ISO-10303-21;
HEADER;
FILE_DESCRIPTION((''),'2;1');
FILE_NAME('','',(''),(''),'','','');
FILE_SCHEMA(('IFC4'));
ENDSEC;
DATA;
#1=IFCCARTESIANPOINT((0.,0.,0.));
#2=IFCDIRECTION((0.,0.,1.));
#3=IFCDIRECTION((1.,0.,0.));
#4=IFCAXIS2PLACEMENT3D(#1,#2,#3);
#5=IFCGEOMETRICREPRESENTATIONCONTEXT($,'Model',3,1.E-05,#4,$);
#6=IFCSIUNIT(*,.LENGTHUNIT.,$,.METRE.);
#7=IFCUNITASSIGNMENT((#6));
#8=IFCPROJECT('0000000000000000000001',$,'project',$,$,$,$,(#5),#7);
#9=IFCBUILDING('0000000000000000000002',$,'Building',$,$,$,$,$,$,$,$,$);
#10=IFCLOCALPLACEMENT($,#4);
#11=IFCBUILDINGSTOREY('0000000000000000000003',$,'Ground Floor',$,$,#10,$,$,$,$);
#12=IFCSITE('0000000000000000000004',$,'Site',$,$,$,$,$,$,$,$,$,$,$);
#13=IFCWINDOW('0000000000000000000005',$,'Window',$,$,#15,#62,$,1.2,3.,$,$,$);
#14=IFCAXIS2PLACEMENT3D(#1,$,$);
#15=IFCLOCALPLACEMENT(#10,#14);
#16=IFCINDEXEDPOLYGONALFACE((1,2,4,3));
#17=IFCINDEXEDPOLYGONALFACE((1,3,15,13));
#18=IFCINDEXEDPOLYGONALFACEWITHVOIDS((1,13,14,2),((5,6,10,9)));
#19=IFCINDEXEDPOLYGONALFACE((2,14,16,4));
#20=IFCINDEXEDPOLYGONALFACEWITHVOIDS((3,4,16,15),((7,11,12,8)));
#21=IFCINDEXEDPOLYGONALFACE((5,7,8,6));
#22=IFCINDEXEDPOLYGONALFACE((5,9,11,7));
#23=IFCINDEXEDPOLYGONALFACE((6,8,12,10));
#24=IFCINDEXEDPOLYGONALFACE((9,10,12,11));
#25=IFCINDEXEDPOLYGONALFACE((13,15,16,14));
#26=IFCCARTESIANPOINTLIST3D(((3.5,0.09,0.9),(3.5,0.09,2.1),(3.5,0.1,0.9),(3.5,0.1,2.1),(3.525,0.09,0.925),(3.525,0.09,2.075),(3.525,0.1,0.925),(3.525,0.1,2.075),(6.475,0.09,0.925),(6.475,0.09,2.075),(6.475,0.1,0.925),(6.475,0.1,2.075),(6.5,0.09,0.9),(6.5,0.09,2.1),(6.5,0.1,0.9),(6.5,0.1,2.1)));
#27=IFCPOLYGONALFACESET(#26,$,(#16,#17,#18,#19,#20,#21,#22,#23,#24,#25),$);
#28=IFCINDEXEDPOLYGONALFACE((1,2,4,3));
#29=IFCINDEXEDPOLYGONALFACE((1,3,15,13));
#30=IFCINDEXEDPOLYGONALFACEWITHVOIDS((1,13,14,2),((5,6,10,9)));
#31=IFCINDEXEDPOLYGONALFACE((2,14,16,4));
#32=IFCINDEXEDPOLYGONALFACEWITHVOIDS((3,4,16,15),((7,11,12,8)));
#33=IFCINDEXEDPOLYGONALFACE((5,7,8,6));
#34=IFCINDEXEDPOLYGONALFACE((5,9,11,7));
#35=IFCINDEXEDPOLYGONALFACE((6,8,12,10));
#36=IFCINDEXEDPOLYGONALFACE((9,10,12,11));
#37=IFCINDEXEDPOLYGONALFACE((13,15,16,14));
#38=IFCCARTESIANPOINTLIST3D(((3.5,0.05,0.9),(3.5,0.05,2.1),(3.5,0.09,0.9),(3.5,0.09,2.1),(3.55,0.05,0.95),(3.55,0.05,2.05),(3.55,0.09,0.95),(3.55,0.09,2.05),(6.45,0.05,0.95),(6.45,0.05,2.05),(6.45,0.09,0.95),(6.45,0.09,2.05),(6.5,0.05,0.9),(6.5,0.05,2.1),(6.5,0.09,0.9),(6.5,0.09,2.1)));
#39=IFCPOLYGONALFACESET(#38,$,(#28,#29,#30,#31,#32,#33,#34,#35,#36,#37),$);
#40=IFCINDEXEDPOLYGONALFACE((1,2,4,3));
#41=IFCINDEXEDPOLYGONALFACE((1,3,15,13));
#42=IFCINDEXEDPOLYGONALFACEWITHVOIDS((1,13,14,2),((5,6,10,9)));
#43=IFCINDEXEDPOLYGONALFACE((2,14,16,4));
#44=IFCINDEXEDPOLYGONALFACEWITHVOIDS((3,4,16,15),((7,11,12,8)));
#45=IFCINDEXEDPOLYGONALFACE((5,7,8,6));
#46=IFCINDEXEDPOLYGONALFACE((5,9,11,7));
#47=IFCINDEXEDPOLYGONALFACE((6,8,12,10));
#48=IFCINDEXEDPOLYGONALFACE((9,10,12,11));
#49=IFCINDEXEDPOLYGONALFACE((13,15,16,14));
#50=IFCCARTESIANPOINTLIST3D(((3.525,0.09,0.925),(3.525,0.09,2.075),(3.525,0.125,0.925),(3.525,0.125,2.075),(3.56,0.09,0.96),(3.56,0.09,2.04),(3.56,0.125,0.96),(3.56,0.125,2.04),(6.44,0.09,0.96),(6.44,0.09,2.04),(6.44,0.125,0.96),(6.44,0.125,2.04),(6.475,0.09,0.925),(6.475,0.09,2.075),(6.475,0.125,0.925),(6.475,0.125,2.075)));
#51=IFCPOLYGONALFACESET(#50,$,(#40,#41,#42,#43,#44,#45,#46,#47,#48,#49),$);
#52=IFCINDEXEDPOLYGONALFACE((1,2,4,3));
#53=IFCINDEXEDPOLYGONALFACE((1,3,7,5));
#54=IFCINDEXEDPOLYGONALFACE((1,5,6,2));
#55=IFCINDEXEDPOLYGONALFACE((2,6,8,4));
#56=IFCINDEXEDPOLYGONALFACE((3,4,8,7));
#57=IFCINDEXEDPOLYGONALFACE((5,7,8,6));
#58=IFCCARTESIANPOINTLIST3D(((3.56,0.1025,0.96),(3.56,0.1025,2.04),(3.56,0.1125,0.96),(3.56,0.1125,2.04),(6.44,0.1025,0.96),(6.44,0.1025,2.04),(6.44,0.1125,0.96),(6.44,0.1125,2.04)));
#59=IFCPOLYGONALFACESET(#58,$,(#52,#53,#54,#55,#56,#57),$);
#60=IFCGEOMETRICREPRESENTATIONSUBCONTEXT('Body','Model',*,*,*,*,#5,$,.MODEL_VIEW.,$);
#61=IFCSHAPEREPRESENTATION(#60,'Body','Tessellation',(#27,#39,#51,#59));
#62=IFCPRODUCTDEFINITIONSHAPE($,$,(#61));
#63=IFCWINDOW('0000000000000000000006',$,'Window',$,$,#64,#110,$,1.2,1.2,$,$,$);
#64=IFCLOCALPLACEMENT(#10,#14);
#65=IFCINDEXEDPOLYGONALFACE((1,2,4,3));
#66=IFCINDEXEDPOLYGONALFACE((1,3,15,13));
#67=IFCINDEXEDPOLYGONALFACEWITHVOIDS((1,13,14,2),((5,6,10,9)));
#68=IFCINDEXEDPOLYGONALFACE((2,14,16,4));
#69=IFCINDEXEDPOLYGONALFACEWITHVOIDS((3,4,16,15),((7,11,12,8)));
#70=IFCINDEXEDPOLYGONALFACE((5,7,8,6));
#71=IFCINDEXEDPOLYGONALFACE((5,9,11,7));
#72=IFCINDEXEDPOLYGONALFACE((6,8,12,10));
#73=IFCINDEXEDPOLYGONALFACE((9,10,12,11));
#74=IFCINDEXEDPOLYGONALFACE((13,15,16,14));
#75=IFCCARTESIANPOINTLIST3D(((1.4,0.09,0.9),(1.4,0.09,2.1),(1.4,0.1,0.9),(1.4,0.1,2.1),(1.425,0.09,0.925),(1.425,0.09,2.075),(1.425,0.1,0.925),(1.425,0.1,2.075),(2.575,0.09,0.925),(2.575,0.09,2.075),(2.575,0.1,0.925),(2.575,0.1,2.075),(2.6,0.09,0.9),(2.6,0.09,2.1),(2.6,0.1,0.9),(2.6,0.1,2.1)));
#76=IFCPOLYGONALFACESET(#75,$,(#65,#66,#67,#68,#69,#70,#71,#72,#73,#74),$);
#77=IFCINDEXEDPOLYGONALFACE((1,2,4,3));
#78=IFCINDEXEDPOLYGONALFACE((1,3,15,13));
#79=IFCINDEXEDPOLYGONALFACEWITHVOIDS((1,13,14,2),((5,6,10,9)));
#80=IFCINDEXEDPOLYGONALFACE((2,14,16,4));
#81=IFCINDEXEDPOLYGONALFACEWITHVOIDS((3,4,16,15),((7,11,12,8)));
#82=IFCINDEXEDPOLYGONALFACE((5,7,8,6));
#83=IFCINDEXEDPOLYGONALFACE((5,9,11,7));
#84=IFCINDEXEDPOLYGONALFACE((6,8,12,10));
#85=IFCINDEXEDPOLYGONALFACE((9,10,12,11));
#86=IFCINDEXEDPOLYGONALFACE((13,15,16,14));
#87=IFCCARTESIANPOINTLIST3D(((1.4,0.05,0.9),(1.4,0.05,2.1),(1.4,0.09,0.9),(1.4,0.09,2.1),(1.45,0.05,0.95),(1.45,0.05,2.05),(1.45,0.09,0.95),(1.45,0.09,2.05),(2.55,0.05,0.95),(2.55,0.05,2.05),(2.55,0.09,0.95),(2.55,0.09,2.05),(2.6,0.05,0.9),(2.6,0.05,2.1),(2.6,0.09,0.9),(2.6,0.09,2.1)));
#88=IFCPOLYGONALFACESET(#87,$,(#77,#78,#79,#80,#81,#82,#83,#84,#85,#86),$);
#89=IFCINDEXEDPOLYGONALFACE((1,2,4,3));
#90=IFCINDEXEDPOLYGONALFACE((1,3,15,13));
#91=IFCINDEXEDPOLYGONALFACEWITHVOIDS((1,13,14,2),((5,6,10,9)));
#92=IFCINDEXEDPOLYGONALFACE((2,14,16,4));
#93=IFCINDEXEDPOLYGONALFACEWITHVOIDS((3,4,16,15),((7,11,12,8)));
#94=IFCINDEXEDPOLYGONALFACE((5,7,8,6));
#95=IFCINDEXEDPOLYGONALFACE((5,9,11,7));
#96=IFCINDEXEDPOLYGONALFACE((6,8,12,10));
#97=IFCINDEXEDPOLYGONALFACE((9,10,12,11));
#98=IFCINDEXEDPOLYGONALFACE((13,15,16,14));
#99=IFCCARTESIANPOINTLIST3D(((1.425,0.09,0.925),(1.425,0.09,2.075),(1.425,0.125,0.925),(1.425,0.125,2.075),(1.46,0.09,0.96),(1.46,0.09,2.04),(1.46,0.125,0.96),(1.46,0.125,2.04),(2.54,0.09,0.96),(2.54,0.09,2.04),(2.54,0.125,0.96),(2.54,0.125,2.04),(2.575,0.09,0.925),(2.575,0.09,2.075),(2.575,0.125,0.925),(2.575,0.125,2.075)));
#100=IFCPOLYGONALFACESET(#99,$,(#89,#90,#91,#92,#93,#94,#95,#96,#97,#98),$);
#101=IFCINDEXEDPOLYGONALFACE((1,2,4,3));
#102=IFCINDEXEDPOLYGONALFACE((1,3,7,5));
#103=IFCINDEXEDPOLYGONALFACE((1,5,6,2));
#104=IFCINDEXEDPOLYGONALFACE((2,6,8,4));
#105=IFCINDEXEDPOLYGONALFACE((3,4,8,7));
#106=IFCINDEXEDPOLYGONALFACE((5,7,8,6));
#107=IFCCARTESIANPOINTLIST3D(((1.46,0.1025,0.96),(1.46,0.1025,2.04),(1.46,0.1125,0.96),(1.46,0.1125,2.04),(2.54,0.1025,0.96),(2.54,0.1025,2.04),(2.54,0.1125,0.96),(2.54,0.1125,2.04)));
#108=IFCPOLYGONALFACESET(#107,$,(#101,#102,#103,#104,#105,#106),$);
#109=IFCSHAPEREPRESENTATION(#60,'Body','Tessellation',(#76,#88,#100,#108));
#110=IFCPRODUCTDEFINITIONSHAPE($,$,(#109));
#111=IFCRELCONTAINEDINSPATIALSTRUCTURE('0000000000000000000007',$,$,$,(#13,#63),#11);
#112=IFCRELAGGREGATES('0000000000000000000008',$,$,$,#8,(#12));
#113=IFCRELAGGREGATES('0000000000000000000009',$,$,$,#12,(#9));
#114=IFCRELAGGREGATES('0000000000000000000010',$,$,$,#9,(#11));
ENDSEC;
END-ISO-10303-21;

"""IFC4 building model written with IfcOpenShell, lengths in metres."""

from ifc_helpers import new_model, si_unit, frame, origin_with_axes, place, context, subcontext, project, spatial, line, indexed_curve, outline, extrude, element, save


model = new_model("IFC4")

# Units and contexts
model_context = context("Model", 3, precision=1e-05, world=origin_with_axes())
body_context = subcontext(model_context, "Body", "Model", "MODEL_VIEW")
ifc_project = project(units=[si_unit("LENGTHUNIT", "METRE")], contexts=[model_context])

# Site, building, storey
site = spatial("IfcSite", under=ifc_project, Name="Site")
building = spatial("IfcBuilding", under=site, Name="Building")
storey_placement = place(None, origin_with_axes())
storey = spatial("IfcBuildingStorey", under=building, at=storey_placement, Name="Ground Floor")

# Windows
window_1_placement = place(storey_placement, frame((3.5, 0.0, 0.9), z_axis=(0.0, 0.0, 1.0), x_axis=(1.0, 0.0, 0.0)))
element("IfcWindow", 1, at=window_1_placement, inside=storey, Name="Window", OverallHeight=1.2, OverallWidth=3.0, context=body_context, shape_type="SweptSolid", body=[
    extrude(outline(indexed_curve([(0.0, 0.0), (3.0, 0.0), (3.0, 1.2), (0.0, 1.2)], segments=[line(1, 2, 3, 4, 1)]), holes=[indexed_curve([(0.025, 0.025), (2.975, 0.025), (2.975, 1.175), (0.025, 1.175)], segments=[line(1, 2, 3, 4, 1)])]), frame((0.0, 0.09, 0.0), z_axis=(0.0, -1.0, 0.0), x_axis=(1.0, 0.0, 0.0)), (0.0, 0.0, -1.0), 0.01),
    extrude(outline(indexed_curve([(0.0, 0.0), (3.0, 0.0), (3.0, 1.2), (0.0, 1.2)], segments=[line(1, 2, 3, 4, 1)]), holes=[indexed_curve([(0.05, 0.05), (2.95, 0.05), (2.95, 1.15), (0.05, 1.15)], segments=[line(1, 2, 3, 4, 1)])]), frame((0.0, 0.05, 0.0), z_axis=(0.0, -1.0, 0.0), x_axis=(1.0, 0.0, 0.0)), (0.0, 0.0, -1.0), 0.04),
    extrude(outline(indexed_curve([(0.0, 0.0), (2.95, 0.0), (2.95, 1.15), (0.0, 1.15)], segments=[line(1, 2, 3, 4, 1)]), holes=[indexed_curve([(0.035, 0.035), (2.915, 0.035), (2.915, 1.115), (0.035, 1.115)], segments=[line(1, 2, 3, 4, 1)])]), frame((0.025, 0.09, 0.025), z_axis=(0.0, -1.0, 0.0), x_axis=(1.0, 0.0, 0.0)), (0.0, 0.0, -1.0), 0.035),
    extrude(outline(indexed_curve([(0.035, 0.035), (2.915, 0.035), (2.915, 1.115), (0.035, 1.115)], segments=[line(1, 2, 3, 4, 1)])), frame((0.025, 0.1025, 0.025), z_axis=(0.0, -1.0, 0.0), x_axis=(1.0, 0.0, 0.0)), (0.0, 0.0, -1.0), 0.01),
])
window_2_placement = place(storey_placement, frame((1.4, 0.0, 0.9), z_axis=(0.0, 0.0, 1.0), x_axis=(1.0, 0.0, 0.0)))
element("IfcWindow", 2, at=window_2_placement, inside=storey, Name="Window", OverallHeight=1.2, OverallWidth=1.2, context=body_context, shape_type="SweptSolid", body=[
    extrude(outline(indexed_curve([(0.0, 0.0), (1.2, 0.0), (1.2, 1.2), (0.0, 1.2)], segments=[line(1, 2, 3, 4, 1)]), holes=[indexed_curve([(0.025, 0.025), (1.175, 0.025), (1.175, 1.175), (0.025, 1.175)], segments=[line(1, 2, 3, 4, 1)])]), frame((0.0, 0.09, 0.0), z_axis=(0.0, -1.0, 0.0), x_axis=(1.0, 0.0, 0.0)), (0.0, 0.0, -1.0), 0.01),
    extrude(outline(indexed_curve([(0.0, 0.0), (1.2, 0.0), (1.2, 1.2), (0.0, 1.2)], segments=[line(1, 2, 3, 4, 1)]), holes=[indexed_curve([(0.05, 0.05), (1.15, 0.05), (1.15, 1.15), (0.05, 1.15)], segments=[line(1, 2, 3, 4, 1)])]), frame((0.0, 0.05, 0.0), z_axis=(0.0, -1.0, 0.0), x_axis=(1.0, 0.0, 0.0)), (0.0, 0.0, -1.0), 0.04),
    extrude(outline(indexed_curve([(0.0, 0.0), (1.15, 0.0), (1.15, 1.15), (0.0, 1.15)], segments=[line(1, 2, 3, 4, 1)]), holes=[indexed_curve([(0.035, 0.035), (1.115, 0.035), (1.115, 1.115), (0.035, 1.115)], segments=[line(1, 2, 3, 4, 1)])]), frame((0.025, 0.09, 0.025), z_axis=(0.0, -1.0, 0.0), x_axis=(1.0, 0.0, 0.0)), (0.0, 0.0, -1.0), 0.035),
    extrude(outline(indexed_curve([(0.035, 0.035), (1.115, 0.035), (1.115, 1.115), (0.035, 1.115)], segments=[line(1, 2, 3, 4, 1)])), frame((0.025, 0.1025, 0.025), z_axis=(0.0, -1.0, 0.0), x_axis=(1.0, 0.0, 0.0)), (0.0, 0.0, -1.0), 0.01),
])

save(model, "model.ifc")
